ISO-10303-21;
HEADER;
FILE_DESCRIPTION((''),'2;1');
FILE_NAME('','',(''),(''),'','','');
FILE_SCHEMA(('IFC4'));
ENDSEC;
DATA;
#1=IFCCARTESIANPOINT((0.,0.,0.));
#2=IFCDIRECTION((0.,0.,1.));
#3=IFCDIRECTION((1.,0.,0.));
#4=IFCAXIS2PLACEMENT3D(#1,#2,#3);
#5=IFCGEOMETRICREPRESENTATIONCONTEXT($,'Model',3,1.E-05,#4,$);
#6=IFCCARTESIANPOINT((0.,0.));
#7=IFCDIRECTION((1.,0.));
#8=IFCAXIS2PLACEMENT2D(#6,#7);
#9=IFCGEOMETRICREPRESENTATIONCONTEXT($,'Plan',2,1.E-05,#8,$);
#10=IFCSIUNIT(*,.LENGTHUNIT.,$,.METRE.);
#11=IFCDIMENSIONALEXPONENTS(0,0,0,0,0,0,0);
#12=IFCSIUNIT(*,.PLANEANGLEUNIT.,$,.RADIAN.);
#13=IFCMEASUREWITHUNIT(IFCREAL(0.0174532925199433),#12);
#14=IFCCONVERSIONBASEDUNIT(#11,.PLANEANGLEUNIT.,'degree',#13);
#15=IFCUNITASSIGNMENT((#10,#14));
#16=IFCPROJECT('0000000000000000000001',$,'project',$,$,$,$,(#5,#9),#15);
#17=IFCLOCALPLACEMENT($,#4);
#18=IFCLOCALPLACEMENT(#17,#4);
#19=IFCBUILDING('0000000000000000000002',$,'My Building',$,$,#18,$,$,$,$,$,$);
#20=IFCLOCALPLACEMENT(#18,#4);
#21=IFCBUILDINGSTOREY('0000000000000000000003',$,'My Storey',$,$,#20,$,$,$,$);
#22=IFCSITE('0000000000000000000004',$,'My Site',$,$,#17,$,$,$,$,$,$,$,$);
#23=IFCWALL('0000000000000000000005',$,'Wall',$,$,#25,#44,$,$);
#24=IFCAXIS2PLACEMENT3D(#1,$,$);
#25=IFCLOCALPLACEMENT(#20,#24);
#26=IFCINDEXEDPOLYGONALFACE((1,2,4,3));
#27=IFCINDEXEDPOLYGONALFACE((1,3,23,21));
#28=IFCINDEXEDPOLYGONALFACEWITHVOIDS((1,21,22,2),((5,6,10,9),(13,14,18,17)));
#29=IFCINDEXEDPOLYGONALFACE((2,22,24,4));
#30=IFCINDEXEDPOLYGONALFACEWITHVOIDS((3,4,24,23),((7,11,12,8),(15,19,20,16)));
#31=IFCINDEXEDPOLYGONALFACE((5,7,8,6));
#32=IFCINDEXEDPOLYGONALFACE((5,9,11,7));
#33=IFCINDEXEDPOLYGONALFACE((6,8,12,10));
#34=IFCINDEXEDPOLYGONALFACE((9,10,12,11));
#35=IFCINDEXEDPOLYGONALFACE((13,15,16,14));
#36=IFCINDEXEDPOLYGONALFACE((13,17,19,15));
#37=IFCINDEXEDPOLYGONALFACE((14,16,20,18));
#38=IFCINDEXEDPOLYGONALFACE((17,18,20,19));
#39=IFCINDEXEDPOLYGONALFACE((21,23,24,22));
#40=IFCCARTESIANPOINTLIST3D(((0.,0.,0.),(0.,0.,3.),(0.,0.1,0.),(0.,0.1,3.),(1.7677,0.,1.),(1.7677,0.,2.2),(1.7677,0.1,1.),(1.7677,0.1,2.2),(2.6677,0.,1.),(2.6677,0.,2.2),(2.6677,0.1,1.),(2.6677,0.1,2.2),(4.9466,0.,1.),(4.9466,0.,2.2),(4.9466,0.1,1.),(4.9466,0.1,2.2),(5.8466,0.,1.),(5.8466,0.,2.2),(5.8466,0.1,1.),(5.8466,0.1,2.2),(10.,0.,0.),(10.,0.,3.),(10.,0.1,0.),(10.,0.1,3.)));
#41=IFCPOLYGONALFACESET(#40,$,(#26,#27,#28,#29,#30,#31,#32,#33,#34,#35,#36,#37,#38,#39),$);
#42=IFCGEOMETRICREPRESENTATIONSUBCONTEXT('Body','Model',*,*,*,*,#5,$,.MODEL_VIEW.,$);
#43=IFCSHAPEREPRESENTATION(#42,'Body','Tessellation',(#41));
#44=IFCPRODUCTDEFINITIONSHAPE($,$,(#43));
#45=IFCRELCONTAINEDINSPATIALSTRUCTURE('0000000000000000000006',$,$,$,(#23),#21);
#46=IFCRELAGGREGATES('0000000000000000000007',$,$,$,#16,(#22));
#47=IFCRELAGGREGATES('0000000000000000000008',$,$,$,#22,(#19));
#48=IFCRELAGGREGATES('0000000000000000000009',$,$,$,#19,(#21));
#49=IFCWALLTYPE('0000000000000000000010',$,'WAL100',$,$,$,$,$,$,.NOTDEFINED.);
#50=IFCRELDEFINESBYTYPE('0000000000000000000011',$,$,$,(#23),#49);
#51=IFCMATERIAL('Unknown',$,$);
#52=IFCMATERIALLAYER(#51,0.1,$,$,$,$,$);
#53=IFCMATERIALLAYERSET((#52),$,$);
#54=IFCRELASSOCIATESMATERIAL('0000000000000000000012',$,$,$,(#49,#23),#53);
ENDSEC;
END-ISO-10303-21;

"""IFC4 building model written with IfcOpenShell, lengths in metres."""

from ifc_helpers import new_model, entity, si_unit, converted_unit, frame, origin_with_axes, origin_2d_with_axis, place, context, subcontext, project, spatial, line, indexed_curve, outline, extrude, source, transform, mapped, material, layer, layer_set, layer_usage, type_object, element, save


model = new_model("IFC4")

# Units and contexts
model_context = context("Model", 3, precision=1e-05, world=origin_with_axes())
plan_context = context("Plan", 2, precision=1e-05, world=origin_2d_with_axis())
body_context = subcontext(model_context, "Body", "Model", "MODEL_VIEW")
ifc_project = project(units=[si_unit("LENGTHUNIT", "METRE"), converted_unit("PLANEANGLEUNIT", "degree", entity("IfcReal", 0.0174532925199433), si_unit("PLANEANGLEUNIT", "RADIAN"), dimensions=[0, 0, 0, 0, 0, 0, 0])], contexts=[model_context, plan_context])

# Site, building, storey
site_placement = place(None, origin_with_axes())
site = spatial("IfcSite", under=ifc_project, at=site_placement, Name="My Site")
building_placement = place(site_placement, origin_with_axes())
building = spatial("IfcBuilding", under=site, at=building_placement, Name="My Building")
storey_placement = place(building_placement, origin_with_axes())
storey = spatial("IfcBuildingStorey", under=building, at=storey_placement, Name="My Storey")

# Wall, openings
ifc_material = material(Name="Unknown")
ifc_layer = layer(ifc_material, 0.1)
ifc_layer_set = layer_set([ifc_layer])
ifc_layer_usage = layer_usage(ifc_layer_set, "AXIS2", "POSITIVE", 0.0)
wall_type = type_object("IfcWallType", Name="WAL100", PredefinedType="NOTDEFINED", material=ifc_layer_set)
wall_placement = place(storey_placement, origin_with_axes())
wall = element("IfcWall", 1, at=wall_placement, inside=storey, type_object=wall_type, material=ifc_layer_usage, Name="Wall", context=body_context, shape_type="SweptSolid", body=[
    extrude(outline(indexed_curve([(0.0, 0.0), (0.0, 0.1), (10.0, 0.1), (10.0, 0.0), (0.0, 0.0)], self_intersect=False)), origin_with_axes(), (0.0, 0.0, 1.0), 3.0),
])
shared_shape = source(origin_with_axes(), body_context, "Body", "SweptSolid", [
    extrude(outline(indexed_curve([(0.0, 0.0), (0.9, 0.0), (0.9, 1.2), (0.0, 1.2)], segments=[line(1, 2, 3, 4, 1)])), frame((0.0, -0.6, 0.0), z_axis=(0.0, -1.0, 0.0), x_axis=(1.0, 0.0, 0.0)), (0.0, 0.0, -1.0), 1.2),
])
opening_1_placement = place(wall_placement, frame((1.7677, 0.0, 1.0), z_axis=(0.0, 0.0, 1.0), x_axis=(1.0, 0.0, 0.0)))
element("IfcOpeningElement", 2, at=opening_1_placement, cuts=wall, PredefinedType="OPENING", context=body_context, shape_type="MappedRepresentation", body=[
    mapped(shared_shape, transform((0.0, 0.0, 0.0), x_axis=(1.0, 0.0, 0.0), y_axis=(0.0, 1.0, 0.0), z_axis=(0.0, 0.0, 1.0), scale=1.0)),
])
opening_2_placement = place(wall_placement, frame((4.9466, 0.0, 1.0), z_axis=(0.0, 0.0, 1.0), x_axis=(1.0, 0.0, 0.0)))
element("IfcOpeningElement", 3, at=opening_2_placement, cuts=wall, PredefinedType="OPENING", context=body_context, shape_type="MappedRepresentation", body=[
    mapped(shared_shape, transform((0.0, 0.0, 0.0), x_axis=(1.0, 0.0, 0.0), y_axis=(0.0, 1.0, 0.0), z_axis=(0.0, 0.0, 1.0), scale=1.0)),
])

save(model, "model.ifc")
